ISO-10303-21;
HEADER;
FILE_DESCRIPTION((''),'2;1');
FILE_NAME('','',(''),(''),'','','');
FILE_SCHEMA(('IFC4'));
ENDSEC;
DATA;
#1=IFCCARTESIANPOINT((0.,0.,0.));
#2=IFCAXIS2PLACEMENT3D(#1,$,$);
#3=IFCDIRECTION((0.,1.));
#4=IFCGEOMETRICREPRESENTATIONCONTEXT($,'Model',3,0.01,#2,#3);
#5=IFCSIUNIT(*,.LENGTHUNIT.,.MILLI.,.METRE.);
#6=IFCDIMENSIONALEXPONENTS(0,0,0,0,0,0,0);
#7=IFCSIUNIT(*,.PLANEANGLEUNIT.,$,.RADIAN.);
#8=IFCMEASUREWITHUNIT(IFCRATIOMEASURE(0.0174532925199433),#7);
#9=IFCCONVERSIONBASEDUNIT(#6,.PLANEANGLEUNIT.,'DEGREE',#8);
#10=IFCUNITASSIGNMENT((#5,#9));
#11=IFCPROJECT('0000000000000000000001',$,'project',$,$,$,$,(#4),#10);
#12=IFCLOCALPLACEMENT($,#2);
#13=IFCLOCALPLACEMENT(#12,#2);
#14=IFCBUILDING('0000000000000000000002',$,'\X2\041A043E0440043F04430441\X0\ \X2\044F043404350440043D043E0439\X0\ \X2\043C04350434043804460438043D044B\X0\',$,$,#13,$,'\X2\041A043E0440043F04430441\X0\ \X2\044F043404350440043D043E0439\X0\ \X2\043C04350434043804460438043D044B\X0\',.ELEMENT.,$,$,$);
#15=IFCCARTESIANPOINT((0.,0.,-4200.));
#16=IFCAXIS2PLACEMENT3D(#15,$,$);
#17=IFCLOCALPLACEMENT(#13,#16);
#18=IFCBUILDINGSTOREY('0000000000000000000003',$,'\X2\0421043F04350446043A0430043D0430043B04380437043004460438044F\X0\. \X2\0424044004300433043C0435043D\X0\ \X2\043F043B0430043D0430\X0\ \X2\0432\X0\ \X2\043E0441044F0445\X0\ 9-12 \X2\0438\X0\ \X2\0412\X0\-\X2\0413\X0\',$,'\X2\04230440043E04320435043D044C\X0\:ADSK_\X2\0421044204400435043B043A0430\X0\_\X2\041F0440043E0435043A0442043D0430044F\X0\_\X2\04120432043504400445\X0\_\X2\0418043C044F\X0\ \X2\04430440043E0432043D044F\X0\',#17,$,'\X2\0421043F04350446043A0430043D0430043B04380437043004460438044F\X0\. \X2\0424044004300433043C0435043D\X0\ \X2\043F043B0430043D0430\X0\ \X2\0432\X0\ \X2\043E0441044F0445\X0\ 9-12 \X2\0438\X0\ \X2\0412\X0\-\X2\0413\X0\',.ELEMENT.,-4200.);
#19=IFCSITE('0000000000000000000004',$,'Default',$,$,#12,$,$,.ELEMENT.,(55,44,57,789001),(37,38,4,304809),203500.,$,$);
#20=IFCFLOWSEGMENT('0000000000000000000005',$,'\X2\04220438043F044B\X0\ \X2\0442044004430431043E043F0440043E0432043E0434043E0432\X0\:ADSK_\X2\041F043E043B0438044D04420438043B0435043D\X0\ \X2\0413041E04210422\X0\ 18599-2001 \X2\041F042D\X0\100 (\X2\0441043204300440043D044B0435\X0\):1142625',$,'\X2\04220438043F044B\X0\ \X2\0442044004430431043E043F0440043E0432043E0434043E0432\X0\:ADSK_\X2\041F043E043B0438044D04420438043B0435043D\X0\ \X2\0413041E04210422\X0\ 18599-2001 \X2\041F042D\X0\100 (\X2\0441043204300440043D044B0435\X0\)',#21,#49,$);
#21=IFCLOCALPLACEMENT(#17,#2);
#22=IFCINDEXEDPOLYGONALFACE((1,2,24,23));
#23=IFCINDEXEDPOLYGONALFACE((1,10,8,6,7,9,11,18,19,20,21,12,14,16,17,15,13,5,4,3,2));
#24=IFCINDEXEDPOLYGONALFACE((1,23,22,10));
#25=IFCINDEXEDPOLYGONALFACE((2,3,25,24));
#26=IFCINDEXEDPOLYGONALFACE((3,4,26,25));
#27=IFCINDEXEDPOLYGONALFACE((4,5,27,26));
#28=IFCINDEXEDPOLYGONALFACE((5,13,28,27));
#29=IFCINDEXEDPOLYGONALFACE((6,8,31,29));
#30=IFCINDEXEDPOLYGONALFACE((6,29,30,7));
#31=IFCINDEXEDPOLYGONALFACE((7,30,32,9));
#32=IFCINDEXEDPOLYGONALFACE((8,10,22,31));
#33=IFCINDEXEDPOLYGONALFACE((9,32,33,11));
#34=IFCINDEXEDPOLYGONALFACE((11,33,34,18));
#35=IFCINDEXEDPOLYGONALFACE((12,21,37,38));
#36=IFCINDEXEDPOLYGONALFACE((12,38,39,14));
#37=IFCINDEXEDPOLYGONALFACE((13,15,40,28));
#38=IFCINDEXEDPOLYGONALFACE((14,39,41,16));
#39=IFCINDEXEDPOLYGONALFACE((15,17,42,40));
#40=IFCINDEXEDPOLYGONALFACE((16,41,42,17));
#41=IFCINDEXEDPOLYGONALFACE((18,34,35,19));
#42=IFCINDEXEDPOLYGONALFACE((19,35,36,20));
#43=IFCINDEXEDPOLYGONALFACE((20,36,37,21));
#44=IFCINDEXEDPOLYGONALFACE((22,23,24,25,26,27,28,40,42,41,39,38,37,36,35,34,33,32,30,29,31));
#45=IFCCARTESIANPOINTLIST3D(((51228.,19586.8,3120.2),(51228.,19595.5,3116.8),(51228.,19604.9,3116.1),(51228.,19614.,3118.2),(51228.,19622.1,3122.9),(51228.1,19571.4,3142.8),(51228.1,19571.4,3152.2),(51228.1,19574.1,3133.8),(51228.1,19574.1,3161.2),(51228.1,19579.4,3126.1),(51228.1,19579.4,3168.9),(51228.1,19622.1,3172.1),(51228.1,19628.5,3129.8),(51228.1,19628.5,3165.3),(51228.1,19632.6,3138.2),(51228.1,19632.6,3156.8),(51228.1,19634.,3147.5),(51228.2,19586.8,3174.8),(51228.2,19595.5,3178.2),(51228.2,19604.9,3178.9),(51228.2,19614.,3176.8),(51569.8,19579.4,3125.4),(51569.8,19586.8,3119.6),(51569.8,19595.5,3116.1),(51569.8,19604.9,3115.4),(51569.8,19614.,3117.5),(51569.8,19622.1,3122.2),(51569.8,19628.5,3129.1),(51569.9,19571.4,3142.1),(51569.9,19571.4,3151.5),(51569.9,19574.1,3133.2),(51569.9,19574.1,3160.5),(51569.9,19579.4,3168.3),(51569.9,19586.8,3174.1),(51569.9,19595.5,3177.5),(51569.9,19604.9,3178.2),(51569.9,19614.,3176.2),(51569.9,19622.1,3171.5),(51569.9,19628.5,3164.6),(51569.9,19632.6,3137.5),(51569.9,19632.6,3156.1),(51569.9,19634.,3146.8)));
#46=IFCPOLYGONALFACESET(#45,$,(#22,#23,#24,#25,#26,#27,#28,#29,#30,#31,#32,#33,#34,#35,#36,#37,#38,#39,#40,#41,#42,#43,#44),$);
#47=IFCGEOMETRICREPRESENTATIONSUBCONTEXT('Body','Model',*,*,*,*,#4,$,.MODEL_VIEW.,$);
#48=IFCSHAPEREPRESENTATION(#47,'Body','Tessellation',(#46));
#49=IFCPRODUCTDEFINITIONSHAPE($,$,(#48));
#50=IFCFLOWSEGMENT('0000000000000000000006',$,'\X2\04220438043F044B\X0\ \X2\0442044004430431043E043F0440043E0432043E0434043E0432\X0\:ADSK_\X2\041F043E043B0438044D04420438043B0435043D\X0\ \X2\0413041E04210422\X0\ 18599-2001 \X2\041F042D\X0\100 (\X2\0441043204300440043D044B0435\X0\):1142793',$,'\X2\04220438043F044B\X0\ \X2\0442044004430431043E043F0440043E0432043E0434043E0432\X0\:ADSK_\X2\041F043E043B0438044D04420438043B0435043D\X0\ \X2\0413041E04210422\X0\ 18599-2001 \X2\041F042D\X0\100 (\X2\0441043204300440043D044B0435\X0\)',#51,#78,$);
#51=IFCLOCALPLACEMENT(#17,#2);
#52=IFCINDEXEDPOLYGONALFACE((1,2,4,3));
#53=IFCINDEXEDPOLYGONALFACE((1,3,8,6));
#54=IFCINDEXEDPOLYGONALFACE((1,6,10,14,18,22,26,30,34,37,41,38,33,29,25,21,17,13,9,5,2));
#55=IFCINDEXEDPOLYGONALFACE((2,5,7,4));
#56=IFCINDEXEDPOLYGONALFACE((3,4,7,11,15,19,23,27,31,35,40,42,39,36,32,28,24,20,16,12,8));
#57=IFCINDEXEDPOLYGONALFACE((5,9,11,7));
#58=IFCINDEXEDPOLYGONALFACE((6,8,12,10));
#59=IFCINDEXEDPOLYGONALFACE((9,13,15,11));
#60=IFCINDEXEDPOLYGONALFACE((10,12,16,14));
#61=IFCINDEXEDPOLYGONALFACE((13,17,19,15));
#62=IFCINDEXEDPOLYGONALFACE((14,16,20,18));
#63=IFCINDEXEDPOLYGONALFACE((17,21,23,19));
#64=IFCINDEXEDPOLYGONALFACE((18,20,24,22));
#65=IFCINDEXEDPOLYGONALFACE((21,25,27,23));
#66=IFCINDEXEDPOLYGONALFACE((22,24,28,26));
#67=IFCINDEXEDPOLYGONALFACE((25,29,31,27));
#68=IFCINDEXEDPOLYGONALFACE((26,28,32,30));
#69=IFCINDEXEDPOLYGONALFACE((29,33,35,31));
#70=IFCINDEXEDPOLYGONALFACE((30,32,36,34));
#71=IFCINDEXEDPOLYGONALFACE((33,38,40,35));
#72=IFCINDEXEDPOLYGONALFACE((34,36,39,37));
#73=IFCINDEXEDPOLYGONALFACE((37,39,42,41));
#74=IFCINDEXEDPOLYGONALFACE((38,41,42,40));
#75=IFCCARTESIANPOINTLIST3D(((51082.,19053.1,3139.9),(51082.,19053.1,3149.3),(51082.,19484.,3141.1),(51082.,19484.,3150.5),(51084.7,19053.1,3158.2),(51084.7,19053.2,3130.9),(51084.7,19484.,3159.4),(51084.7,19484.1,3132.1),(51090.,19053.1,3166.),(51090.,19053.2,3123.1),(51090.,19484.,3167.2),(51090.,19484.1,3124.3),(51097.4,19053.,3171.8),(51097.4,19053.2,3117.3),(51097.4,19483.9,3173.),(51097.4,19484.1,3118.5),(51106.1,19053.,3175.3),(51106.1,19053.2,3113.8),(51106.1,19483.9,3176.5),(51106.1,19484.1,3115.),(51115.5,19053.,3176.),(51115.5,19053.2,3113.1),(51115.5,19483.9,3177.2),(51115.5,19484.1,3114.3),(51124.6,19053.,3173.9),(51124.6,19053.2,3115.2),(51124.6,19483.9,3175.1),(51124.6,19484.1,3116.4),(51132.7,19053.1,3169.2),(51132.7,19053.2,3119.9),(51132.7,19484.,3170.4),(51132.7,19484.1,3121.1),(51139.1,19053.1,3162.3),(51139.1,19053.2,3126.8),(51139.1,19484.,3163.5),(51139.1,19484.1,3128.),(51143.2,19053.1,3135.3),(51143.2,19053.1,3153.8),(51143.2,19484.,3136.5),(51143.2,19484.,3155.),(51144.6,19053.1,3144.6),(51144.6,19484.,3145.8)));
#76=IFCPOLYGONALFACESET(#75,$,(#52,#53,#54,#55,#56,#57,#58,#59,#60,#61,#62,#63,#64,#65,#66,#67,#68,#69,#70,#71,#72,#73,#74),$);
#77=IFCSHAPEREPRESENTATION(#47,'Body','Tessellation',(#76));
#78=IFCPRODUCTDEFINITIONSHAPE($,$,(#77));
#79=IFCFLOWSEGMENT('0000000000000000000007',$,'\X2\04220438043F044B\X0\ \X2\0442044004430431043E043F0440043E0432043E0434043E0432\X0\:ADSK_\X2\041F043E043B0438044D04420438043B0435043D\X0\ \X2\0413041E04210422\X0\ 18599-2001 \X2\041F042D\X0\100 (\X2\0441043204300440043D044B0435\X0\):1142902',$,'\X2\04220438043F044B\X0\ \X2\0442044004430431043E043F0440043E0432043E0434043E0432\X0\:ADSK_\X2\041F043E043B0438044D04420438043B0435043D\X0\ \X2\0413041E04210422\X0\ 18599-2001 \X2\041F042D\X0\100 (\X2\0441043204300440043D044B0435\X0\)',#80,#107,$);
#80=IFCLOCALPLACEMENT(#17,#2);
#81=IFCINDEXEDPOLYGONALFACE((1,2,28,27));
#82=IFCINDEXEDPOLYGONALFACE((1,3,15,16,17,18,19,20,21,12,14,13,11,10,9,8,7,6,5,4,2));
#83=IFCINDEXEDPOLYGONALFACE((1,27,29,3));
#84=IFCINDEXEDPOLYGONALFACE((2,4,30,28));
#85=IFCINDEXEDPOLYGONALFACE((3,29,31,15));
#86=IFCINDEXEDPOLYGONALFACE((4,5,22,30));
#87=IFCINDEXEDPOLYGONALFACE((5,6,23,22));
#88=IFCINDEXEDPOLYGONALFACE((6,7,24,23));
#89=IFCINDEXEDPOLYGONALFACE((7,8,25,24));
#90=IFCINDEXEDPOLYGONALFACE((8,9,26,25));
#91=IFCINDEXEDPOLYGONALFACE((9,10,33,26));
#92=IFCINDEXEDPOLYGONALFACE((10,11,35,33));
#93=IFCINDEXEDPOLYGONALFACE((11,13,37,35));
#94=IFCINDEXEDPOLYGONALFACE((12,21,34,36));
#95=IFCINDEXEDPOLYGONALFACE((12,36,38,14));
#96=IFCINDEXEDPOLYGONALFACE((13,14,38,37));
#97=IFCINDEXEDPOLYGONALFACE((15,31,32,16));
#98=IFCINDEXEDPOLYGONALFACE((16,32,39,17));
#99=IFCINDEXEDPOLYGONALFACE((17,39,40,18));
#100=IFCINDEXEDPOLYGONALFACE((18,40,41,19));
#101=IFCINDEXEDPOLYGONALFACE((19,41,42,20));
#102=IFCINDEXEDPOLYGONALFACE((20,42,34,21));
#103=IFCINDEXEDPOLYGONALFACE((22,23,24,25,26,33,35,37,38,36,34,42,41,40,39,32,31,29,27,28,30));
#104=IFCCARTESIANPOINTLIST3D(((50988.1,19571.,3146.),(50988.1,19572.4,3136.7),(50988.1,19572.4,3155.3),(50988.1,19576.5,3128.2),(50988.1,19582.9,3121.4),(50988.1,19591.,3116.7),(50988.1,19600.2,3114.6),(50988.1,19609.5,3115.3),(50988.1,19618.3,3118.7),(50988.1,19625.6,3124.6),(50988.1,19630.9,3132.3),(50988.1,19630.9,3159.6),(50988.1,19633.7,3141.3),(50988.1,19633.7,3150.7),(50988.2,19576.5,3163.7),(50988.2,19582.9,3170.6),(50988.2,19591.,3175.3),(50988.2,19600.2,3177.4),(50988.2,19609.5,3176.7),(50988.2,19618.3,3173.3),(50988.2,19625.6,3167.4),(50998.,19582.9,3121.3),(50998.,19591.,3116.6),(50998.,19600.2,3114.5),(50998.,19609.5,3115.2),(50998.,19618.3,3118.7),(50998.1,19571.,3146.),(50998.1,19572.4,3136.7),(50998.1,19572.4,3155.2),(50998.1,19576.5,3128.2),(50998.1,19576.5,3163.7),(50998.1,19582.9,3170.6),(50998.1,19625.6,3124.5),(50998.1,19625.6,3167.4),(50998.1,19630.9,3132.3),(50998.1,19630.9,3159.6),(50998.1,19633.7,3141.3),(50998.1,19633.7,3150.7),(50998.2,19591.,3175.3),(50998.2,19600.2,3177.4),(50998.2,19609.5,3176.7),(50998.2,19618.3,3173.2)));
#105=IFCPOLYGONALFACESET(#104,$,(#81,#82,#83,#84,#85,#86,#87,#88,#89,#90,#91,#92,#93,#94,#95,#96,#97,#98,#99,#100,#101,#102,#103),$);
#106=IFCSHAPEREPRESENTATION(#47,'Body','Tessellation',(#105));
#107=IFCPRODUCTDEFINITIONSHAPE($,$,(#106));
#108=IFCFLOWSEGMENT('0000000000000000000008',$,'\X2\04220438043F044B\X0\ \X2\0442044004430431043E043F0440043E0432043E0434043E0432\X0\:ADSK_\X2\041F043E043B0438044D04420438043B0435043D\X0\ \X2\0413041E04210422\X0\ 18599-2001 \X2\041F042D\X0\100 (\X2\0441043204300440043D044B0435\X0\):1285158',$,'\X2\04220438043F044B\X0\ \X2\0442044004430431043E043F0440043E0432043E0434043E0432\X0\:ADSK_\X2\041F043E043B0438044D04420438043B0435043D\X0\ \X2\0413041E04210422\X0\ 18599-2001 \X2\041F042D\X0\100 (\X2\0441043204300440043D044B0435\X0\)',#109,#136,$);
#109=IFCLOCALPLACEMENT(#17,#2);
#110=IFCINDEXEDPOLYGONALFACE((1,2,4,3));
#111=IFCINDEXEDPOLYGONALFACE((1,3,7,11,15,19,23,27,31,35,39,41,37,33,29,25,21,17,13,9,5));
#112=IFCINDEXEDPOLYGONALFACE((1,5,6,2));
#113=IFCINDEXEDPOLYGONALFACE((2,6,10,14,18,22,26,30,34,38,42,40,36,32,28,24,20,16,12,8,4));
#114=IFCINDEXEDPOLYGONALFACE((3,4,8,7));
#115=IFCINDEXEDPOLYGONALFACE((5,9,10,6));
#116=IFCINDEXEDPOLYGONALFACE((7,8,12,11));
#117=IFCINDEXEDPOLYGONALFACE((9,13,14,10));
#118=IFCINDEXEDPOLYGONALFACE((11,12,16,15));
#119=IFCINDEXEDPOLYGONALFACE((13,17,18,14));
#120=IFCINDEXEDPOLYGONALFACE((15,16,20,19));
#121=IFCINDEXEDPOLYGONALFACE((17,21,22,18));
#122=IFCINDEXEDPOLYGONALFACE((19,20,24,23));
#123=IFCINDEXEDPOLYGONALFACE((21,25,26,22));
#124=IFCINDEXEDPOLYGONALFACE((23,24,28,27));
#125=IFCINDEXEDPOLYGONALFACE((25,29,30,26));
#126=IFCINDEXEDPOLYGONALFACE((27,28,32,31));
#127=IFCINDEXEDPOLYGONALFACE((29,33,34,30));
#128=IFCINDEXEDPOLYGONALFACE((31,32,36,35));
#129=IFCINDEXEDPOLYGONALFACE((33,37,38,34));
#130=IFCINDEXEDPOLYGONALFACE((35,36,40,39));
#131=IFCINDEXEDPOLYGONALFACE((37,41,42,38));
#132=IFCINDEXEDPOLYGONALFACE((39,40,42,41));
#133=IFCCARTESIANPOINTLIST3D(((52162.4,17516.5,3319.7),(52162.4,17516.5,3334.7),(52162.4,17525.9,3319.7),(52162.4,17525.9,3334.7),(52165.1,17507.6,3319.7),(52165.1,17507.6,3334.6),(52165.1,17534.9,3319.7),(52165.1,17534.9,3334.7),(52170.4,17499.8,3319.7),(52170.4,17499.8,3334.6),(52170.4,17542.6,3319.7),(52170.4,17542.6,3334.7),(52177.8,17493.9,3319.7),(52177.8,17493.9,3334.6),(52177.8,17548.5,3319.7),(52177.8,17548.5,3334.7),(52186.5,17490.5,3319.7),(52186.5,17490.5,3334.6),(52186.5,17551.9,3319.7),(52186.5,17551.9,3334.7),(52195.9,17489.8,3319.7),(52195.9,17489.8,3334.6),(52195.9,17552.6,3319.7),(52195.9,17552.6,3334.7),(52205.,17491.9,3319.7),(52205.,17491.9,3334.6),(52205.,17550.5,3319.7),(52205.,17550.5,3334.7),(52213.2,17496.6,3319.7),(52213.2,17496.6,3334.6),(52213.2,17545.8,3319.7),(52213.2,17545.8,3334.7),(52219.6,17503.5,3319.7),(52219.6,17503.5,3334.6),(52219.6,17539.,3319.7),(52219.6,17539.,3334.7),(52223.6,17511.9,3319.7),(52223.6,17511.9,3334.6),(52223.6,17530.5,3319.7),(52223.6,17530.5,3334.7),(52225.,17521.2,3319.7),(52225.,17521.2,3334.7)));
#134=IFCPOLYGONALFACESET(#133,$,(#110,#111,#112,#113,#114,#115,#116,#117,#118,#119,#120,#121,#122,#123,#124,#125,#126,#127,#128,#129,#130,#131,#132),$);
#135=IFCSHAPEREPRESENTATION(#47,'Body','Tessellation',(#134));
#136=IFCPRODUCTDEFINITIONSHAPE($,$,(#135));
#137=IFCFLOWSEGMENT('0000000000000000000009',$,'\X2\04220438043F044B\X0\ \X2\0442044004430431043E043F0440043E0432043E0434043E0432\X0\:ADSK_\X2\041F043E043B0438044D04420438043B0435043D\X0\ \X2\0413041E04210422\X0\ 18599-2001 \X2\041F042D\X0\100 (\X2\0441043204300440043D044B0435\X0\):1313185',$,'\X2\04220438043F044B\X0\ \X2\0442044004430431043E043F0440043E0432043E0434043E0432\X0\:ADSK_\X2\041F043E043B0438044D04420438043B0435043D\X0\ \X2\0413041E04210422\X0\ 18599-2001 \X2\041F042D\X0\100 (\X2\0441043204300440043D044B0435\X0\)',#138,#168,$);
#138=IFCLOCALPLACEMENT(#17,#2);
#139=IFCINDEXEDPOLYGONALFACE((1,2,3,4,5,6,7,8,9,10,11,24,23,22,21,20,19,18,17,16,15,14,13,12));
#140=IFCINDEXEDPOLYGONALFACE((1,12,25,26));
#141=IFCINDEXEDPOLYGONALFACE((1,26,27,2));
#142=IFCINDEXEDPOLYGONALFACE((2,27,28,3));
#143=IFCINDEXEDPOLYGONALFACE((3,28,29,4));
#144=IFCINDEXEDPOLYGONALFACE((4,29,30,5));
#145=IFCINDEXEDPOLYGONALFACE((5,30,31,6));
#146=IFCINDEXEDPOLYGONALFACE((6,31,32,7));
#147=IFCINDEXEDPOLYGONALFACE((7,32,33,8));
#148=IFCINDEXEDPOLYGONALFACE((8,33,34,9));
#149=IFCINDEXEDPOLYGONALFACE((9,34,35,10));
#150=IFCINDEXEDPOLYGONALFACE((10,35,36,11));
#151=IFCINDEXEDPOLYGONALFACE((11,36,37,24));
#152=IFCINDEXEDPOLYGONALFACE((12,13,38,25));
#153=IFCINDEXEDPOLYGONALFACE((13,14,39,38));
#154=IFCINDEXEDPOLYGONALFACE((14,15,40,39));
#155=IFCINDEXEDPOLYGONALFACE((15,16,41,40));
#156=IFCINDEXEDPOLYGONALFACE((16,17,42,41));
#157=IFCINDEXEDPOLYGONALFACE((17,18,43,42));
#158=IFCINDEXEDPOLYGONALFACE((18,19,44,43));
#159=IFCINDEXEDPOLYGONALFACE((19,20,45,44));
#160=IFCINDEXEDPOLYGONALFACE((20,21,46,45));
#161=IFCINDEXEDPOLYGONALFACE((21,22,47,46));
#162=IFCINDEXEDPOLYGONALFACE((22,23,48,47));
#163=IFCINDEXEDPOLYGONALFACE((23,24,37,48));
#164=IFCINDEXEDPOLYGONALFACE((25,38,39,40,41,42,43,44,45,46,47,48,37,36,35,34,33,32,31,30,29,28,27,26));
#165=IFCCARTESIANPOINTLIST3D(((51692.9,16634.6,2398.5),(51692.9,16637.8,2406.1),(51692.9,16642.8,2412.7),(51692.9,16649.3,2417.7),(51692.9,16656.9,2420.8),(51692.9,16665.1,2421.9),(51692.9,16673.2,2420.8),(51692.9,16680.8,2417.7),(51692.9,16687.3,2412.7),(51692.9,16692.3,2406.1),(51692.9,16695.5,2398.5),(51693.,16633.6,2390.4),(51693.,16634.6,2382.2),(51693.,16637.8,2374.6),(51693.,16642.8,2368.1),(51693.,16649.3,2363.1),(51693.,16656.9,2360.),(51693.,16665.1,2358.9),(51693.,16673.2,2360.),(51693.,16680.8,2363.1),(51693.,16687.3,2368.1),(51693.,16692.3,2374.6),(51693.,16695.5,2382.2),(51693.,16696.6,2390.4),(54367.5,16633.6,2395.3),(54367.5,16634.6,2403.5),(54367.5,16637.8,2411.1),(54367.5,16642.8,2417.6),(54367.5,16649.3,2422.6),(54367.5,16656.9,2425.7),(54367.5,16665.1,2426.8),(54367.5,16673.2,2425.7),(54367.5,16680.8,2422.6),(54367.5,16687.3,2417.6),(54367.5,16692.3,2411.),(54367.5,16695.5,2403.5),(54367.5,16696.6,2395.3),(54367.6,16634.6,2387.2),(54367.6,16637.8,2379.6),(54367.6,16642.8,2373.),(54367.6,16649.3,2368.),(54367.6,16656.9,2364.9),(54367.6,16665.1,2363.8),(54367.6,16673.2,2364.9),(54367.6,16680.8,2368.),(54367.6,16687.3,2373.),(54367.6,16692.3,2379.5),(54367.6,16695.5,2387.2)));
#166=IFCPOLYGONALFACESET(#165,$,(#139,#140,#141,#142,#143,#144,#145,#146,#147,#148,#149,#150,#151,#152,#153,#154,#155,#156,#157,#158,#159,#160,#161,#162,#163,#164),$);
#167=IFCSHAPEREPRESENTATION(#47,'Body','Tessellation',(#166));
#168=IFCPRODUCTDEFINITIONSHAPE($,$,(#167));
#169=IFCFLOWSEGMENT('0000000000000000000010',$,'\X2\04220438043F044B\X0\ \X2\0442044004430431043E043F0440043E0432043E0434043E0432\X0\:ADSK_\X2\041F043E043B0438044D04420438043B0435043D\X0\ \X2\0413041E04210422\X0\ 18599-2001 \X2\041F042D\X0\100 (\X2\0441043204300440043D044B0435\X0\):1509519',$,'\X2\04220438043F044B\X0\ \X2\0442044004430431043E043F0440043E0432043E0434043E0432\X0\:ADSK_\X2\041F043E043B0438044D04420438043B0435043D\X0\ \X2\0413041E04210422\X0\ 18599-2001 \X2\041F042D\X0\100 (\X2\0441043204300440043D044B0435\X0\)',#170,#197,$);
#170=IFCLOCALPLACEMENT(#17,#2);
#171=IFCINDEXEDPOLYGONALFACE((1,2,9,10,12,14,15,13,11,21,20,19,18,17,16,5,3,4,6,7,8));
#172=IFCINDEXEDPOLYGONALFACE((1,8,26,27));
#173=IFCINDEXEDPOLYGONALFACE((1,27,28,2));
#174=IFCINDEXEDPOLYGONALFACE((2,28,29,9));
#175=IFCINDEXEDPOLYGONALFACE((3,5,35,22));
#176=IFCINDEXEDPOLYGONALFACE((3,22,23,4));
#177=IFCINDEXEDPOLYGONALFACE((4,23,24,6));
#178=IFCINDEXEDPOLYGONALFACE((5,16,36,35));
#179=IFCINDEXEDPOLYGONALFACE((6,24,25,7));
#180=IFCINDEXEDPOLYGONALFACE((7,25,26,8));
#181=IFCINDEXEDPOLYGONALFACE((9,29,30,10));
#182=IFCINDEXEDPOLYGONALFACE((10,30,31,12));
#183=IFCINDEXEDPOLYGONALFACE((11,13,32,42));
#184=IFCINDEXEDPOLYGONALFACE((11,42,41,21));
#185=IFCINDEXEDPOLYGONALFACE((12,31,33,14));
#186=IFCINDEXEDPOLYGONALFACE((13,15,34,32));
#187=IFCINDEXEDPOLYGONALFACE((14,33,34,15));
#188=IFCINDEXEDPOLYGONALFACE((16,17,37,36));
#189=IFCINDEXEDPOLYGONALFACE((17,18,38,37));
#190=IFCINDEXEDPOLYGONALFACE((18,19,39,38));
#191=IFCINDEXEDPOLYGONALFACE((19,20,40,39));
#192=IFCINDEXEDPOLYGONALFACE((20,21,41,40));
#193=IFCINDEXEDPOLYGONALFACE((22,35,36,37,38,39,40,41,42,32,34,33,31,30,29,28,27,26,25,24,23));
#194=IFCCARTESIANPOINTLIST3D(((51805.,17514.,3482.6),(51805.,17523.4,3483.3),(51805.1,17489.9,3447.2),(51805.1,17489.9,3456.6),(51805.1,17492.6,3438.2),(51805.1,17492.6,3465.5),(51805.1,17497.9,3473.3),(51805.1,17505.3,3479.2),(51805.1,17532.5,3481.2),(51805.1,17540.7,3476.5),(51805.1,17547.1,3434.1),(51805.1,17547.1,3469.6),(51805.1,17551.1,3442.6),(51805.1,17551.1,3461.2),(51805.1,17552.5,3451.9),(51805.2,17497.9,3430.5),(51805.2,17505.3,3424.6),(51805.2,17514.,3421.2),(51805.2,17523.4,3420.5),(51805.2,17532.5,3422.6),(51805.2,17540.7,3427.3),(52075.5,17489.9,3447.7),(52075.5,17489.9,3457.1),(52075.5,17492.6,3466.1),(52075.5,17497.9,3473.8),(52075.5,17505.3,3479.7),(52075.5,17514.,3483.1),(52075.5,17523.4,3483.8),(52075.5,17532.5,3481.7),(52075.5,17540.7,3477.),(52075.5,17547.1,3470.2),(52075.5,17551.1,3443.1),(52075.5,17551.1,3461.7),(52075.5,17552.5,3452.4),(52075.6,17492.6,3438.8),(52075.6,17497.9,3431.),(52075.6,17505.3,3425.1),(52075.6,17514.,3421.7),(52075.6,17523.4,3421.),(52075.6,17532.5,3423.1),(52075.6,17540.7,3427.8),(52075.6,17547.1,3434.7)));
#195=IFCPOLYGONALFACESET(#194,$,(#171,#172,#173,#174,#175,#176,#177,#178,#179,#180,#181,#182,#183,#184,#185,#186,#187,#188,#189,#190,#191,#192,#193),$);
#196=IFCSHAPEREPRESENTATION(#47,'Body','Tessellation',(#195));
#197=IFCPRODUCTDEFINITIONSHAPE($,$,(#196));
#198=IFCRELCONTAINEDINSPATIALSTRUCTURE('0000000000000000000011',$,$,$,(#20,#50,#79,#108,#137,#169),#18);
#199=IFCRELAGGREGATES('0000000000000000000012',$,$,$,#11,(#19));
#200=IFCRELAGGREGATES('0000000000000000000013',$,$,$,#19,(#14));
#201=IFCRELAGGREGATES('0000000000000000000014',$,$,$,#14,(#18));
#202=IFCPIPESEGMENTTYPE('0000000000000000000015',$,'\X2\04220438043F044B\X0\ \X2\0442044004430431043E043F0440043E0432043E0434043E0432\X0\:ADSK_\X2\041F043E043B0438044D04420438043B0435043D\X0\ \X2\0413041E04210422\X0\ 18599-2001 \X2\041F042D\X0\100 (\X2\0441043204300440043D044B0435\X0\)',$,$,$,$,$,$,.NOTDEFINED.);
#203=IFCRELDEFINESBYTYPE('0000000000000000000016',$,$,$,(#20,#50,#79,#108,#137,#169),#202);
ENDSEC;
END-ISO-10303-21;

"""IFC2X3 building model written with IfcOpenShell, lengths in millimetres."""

from ifc_helpers import new_model, entity, si_unit, converted_unit, direction, frame, origin, origin_2d_with_axis, place, context, subcontext, project, spatial, polyline, circle, outline, extrude, type_object, element, save


model = new_model("IFC2X3")

# Units and contexts
model_context = context("Model", 3, precision=0.01, world=origin(), true_north=direction((0.0, 1.0)))
body_context = subcontext(model_context, "Body", "Model", "MODEL_VIEW")
ifc_project = project(units=[si_unit("LENGTHUNIT", "METRE", prefix="MILLI"), converted_unit("PLANEANGLEUNIT", "DEGREE", entity("IfcRatioMeasure", 0.0174532925199433), si_unit("PLANEANGLEUNIT", "RADIAN"), dimensions=[0, 0, 0, 0, 0, 0, 0])], contexts=[model_context])

# Site, building, storey
site_placement = place(None, origin())
site = spatial("IfcSite", under=ifc_project, at=site_placement, Name="Default", CompositionType="ELEMENT", RefLatitude=(55, 44, 57, 789001), RefLongitude=(37, 38, 4, 304809), RefElevation=203500.0)
building_placement = place(site_placement, origin())
building = spatial("IfcBuilding", under=site, at=building_placement, Name="Корпус ядерной медицины", LongName="Корпус ядерной медицины", CompositionType="ELEMENT")
storey_placement = place(building_placement, frame((0.0, 0.0, -4200.0)))
storey = spatial("IfcBuildingStorey", under=building, at=storey_placement, Name="Спецканализация. Фрагмен плана в осях 9-12 и В-Г", ObjectType="Уровень:ADSK_Стрелка_Проектная_Вверх_Имя уровня", LongName="Спецканализация. Фрагмен плана в осях 9-12 и В-Г", CompositionType="ELEMENT", Elevation=-4200.0)

# Flow segments
pipe_segment_type = type_object("IfcPipeSegmentType", Name="Типы трубопроводов:ADSK_Полиэтилен ГОСТ 18599-2001 ПЭ100 (сварные)", PredefinedType="NOTDEFINED")
flow_segment_1_placement = place(storey_placement, frame((51228.0, 19569.4, 3113.7)))
element("IfcFlowSegment", 1, at=flow_segment_1_placement, inside=storey, type_object=pipe_segment_type, Name="Типы трубопроводов:ADSK_Полиэтилен ГОСТ 18599-2001 ПЭ100 (сварные):1142625", ObjectType="Типы трубопроводов:ADSK_Полиэтилен ГОСТ 18599-2001 ПЭ100 (сварные)", context=body_context, shape_type="SweptSolid", body=[
    extrude(circle(Radius=31.5, at=origin_2d_with_axis()), frame((341.9, 33.1, 33.1), z_axis=(-0.999998, 0.0, 0.002), x_axis=(0.0, 1.0, 0.0)), (0.0, 0.0, 1.0), 341.8),
])
flow_segment_2_placement = place(storey_placement, frame((51080.0, 19053.0, 3111.5)))
element("IfcFlowSegment", 2, at=flow_segment_2_placement, inside=storey, type_object=pipe_segment_type, Name="Типы трубопроводов:ADSK_Полиэтилен ГОСТ 18599-2001 ПЭ100 (сварные):1142793", ObjectType="Типы трубопроводов:ADSK_Полиэтилен ГОСТ 18599-2001 ПЭ100 (сварные)", context=body_context, shape_type="SweptSolid", body=[
    extrude(circle(Radius=31.5, at=origin_2d_with_axis()), frame((33.1, 0.1, 33.1), z_axis=(0.0, 0.999996, 0.002784), x_axis=(1.0, 0.0, 0.0)), (0.0, 0.0, 1.0), 430.9),
])
flow_segment_3_placement = place(storey_placement, frame((50988.1, 19569.4, 3112.9)))
element("IfcFlowSegment", 3, at=flow_segment_3_placement, inside=storey, type_object=pipe_segment_type, Name="Типы трубопроводов:ADSK_Полиэтилен ГОСТ 18599-2001 ПЭ100 (сварные):1142902", ObjectType="Типы трубопроводов:ADSK_Полиэтилен ГОСТ 18599-2001 ПЭ100 (сварные)", context=body_context, shape_type="SweptSolid", body=[
    extrude(circle(Radius=31.5, at=origin_2d_with_axis()), frame((0.1, 33.1, 33.1), z_axis=(0.999998, 0.0, -0.002), x_axis=(0.0, -1.0, 0.0)), (0.0, 0.0, 1.0), 10.0),
])
flow_segment_4_placement = place(storey_placement, frame((52160.4, 17488.1, 3319.7)))
element("IfcFlowSegment", 4, at=flow_segment_4_placement, inside=storey, type_object=pipe_segment_type, Name="Типы трубопроводов:ADSK_Полиэтилен ГОСТ 18599-2001 ПЭ100 (сварные):1285158", ObjectType="Типы трубопроводов:ADSK_Полиэтилен ГОСТ 18599-2001 ПЭ100 (сварные)", context=body_context, shape_type="SweptSolid", body=[
    extrude(circle(Radius=31.5, at=origin_2d_with_axis()), frame((33.1, 33.1, 0.0), z_axis=(0.000001, -0.000133, 1.0), x_axis=(1.0, 0.0, -0.000001)), (0.0, 0.0, 1.0), 14.9),
])
flow_segment_5_placement = place(storey_placement, frame((51692.9, 16632.0, 2357.3)))
element("IfcFlowSegment", 5, at=flow_segment_5_placement, inside=storey, type_object=pipe_segment_type, Name="Типы трубопроводов:ADSK_Полиэтилен ГОСТ 18599-2001 ПЭ100 (сварные):1313185", ObjectType="Типы трубопроводов:ADSK_Полиэтилен ГОСТ 18599-2001 ПЭ100 (сварные)", context=body_context, shape_type="SweptSolid", body=[
    extrude(outline(polyline([(-4.1, -31.2), (4.1, -31.2), (12.1, -29.1), (19.2, -25.0), (25.0, -19.2), (29.1, -12.1), (31.2, -4.1), (31.2, 4.1), (29.1, 12.1), (25.0, 19.2), (19.2, 25.0), (12.1, 29.1), (4.1, 31.2), (-4.1, 31.2), (-12.1, 29.1), (-19.2, 25.0), (-25.0, 19.2), (-29.1, 12.1), (-31.2, 4.1), (-31.2, -4.1), (-29.1, -12.1), (-25.0, -19.2), (-19.2, -25.0), (-12.1, -29.1), (-4.1, -31.2)])), frame((0.1, 33.1, 33.1), z_axis=(0.999998, 0.0, 0.001837), x_axis=(-0.001821, -0.130526, 0.991443)), (0.0, 0.0, 1.0), 2674.6),
])
flow_segment_6_placement = place(storey_placement, frame((51805.1, 17487.9, 3418.8)))
element("IfcFlowSegment", 6, at=flow_segment_6_placement, inside=storey, type_object=pipe_segment_type, Name="Типы трубопроводов:ADSK_Полиэтилен ГОСТ 18599-2001 ПЭ100 (сварные):1509519", ObjectType="Типы трубопроводов:ADSK_Полиэтилен ГОСТ 18599-2001 ПЭ100 (сварные)", context=body_context, shape_type="SweptSolid", body=[
    extrude(circle(Radius=31.5, at=origin_2d_with_axis()), frame((0.1, 33.1, 33.1), z_axis=(0.999998, -0.000004, 0.001999), x_axis=(0.000004, 1.0, 0.0)), (0.0, 0.0, 1.0), 270.4),
])

save(model, "model.ifc")
